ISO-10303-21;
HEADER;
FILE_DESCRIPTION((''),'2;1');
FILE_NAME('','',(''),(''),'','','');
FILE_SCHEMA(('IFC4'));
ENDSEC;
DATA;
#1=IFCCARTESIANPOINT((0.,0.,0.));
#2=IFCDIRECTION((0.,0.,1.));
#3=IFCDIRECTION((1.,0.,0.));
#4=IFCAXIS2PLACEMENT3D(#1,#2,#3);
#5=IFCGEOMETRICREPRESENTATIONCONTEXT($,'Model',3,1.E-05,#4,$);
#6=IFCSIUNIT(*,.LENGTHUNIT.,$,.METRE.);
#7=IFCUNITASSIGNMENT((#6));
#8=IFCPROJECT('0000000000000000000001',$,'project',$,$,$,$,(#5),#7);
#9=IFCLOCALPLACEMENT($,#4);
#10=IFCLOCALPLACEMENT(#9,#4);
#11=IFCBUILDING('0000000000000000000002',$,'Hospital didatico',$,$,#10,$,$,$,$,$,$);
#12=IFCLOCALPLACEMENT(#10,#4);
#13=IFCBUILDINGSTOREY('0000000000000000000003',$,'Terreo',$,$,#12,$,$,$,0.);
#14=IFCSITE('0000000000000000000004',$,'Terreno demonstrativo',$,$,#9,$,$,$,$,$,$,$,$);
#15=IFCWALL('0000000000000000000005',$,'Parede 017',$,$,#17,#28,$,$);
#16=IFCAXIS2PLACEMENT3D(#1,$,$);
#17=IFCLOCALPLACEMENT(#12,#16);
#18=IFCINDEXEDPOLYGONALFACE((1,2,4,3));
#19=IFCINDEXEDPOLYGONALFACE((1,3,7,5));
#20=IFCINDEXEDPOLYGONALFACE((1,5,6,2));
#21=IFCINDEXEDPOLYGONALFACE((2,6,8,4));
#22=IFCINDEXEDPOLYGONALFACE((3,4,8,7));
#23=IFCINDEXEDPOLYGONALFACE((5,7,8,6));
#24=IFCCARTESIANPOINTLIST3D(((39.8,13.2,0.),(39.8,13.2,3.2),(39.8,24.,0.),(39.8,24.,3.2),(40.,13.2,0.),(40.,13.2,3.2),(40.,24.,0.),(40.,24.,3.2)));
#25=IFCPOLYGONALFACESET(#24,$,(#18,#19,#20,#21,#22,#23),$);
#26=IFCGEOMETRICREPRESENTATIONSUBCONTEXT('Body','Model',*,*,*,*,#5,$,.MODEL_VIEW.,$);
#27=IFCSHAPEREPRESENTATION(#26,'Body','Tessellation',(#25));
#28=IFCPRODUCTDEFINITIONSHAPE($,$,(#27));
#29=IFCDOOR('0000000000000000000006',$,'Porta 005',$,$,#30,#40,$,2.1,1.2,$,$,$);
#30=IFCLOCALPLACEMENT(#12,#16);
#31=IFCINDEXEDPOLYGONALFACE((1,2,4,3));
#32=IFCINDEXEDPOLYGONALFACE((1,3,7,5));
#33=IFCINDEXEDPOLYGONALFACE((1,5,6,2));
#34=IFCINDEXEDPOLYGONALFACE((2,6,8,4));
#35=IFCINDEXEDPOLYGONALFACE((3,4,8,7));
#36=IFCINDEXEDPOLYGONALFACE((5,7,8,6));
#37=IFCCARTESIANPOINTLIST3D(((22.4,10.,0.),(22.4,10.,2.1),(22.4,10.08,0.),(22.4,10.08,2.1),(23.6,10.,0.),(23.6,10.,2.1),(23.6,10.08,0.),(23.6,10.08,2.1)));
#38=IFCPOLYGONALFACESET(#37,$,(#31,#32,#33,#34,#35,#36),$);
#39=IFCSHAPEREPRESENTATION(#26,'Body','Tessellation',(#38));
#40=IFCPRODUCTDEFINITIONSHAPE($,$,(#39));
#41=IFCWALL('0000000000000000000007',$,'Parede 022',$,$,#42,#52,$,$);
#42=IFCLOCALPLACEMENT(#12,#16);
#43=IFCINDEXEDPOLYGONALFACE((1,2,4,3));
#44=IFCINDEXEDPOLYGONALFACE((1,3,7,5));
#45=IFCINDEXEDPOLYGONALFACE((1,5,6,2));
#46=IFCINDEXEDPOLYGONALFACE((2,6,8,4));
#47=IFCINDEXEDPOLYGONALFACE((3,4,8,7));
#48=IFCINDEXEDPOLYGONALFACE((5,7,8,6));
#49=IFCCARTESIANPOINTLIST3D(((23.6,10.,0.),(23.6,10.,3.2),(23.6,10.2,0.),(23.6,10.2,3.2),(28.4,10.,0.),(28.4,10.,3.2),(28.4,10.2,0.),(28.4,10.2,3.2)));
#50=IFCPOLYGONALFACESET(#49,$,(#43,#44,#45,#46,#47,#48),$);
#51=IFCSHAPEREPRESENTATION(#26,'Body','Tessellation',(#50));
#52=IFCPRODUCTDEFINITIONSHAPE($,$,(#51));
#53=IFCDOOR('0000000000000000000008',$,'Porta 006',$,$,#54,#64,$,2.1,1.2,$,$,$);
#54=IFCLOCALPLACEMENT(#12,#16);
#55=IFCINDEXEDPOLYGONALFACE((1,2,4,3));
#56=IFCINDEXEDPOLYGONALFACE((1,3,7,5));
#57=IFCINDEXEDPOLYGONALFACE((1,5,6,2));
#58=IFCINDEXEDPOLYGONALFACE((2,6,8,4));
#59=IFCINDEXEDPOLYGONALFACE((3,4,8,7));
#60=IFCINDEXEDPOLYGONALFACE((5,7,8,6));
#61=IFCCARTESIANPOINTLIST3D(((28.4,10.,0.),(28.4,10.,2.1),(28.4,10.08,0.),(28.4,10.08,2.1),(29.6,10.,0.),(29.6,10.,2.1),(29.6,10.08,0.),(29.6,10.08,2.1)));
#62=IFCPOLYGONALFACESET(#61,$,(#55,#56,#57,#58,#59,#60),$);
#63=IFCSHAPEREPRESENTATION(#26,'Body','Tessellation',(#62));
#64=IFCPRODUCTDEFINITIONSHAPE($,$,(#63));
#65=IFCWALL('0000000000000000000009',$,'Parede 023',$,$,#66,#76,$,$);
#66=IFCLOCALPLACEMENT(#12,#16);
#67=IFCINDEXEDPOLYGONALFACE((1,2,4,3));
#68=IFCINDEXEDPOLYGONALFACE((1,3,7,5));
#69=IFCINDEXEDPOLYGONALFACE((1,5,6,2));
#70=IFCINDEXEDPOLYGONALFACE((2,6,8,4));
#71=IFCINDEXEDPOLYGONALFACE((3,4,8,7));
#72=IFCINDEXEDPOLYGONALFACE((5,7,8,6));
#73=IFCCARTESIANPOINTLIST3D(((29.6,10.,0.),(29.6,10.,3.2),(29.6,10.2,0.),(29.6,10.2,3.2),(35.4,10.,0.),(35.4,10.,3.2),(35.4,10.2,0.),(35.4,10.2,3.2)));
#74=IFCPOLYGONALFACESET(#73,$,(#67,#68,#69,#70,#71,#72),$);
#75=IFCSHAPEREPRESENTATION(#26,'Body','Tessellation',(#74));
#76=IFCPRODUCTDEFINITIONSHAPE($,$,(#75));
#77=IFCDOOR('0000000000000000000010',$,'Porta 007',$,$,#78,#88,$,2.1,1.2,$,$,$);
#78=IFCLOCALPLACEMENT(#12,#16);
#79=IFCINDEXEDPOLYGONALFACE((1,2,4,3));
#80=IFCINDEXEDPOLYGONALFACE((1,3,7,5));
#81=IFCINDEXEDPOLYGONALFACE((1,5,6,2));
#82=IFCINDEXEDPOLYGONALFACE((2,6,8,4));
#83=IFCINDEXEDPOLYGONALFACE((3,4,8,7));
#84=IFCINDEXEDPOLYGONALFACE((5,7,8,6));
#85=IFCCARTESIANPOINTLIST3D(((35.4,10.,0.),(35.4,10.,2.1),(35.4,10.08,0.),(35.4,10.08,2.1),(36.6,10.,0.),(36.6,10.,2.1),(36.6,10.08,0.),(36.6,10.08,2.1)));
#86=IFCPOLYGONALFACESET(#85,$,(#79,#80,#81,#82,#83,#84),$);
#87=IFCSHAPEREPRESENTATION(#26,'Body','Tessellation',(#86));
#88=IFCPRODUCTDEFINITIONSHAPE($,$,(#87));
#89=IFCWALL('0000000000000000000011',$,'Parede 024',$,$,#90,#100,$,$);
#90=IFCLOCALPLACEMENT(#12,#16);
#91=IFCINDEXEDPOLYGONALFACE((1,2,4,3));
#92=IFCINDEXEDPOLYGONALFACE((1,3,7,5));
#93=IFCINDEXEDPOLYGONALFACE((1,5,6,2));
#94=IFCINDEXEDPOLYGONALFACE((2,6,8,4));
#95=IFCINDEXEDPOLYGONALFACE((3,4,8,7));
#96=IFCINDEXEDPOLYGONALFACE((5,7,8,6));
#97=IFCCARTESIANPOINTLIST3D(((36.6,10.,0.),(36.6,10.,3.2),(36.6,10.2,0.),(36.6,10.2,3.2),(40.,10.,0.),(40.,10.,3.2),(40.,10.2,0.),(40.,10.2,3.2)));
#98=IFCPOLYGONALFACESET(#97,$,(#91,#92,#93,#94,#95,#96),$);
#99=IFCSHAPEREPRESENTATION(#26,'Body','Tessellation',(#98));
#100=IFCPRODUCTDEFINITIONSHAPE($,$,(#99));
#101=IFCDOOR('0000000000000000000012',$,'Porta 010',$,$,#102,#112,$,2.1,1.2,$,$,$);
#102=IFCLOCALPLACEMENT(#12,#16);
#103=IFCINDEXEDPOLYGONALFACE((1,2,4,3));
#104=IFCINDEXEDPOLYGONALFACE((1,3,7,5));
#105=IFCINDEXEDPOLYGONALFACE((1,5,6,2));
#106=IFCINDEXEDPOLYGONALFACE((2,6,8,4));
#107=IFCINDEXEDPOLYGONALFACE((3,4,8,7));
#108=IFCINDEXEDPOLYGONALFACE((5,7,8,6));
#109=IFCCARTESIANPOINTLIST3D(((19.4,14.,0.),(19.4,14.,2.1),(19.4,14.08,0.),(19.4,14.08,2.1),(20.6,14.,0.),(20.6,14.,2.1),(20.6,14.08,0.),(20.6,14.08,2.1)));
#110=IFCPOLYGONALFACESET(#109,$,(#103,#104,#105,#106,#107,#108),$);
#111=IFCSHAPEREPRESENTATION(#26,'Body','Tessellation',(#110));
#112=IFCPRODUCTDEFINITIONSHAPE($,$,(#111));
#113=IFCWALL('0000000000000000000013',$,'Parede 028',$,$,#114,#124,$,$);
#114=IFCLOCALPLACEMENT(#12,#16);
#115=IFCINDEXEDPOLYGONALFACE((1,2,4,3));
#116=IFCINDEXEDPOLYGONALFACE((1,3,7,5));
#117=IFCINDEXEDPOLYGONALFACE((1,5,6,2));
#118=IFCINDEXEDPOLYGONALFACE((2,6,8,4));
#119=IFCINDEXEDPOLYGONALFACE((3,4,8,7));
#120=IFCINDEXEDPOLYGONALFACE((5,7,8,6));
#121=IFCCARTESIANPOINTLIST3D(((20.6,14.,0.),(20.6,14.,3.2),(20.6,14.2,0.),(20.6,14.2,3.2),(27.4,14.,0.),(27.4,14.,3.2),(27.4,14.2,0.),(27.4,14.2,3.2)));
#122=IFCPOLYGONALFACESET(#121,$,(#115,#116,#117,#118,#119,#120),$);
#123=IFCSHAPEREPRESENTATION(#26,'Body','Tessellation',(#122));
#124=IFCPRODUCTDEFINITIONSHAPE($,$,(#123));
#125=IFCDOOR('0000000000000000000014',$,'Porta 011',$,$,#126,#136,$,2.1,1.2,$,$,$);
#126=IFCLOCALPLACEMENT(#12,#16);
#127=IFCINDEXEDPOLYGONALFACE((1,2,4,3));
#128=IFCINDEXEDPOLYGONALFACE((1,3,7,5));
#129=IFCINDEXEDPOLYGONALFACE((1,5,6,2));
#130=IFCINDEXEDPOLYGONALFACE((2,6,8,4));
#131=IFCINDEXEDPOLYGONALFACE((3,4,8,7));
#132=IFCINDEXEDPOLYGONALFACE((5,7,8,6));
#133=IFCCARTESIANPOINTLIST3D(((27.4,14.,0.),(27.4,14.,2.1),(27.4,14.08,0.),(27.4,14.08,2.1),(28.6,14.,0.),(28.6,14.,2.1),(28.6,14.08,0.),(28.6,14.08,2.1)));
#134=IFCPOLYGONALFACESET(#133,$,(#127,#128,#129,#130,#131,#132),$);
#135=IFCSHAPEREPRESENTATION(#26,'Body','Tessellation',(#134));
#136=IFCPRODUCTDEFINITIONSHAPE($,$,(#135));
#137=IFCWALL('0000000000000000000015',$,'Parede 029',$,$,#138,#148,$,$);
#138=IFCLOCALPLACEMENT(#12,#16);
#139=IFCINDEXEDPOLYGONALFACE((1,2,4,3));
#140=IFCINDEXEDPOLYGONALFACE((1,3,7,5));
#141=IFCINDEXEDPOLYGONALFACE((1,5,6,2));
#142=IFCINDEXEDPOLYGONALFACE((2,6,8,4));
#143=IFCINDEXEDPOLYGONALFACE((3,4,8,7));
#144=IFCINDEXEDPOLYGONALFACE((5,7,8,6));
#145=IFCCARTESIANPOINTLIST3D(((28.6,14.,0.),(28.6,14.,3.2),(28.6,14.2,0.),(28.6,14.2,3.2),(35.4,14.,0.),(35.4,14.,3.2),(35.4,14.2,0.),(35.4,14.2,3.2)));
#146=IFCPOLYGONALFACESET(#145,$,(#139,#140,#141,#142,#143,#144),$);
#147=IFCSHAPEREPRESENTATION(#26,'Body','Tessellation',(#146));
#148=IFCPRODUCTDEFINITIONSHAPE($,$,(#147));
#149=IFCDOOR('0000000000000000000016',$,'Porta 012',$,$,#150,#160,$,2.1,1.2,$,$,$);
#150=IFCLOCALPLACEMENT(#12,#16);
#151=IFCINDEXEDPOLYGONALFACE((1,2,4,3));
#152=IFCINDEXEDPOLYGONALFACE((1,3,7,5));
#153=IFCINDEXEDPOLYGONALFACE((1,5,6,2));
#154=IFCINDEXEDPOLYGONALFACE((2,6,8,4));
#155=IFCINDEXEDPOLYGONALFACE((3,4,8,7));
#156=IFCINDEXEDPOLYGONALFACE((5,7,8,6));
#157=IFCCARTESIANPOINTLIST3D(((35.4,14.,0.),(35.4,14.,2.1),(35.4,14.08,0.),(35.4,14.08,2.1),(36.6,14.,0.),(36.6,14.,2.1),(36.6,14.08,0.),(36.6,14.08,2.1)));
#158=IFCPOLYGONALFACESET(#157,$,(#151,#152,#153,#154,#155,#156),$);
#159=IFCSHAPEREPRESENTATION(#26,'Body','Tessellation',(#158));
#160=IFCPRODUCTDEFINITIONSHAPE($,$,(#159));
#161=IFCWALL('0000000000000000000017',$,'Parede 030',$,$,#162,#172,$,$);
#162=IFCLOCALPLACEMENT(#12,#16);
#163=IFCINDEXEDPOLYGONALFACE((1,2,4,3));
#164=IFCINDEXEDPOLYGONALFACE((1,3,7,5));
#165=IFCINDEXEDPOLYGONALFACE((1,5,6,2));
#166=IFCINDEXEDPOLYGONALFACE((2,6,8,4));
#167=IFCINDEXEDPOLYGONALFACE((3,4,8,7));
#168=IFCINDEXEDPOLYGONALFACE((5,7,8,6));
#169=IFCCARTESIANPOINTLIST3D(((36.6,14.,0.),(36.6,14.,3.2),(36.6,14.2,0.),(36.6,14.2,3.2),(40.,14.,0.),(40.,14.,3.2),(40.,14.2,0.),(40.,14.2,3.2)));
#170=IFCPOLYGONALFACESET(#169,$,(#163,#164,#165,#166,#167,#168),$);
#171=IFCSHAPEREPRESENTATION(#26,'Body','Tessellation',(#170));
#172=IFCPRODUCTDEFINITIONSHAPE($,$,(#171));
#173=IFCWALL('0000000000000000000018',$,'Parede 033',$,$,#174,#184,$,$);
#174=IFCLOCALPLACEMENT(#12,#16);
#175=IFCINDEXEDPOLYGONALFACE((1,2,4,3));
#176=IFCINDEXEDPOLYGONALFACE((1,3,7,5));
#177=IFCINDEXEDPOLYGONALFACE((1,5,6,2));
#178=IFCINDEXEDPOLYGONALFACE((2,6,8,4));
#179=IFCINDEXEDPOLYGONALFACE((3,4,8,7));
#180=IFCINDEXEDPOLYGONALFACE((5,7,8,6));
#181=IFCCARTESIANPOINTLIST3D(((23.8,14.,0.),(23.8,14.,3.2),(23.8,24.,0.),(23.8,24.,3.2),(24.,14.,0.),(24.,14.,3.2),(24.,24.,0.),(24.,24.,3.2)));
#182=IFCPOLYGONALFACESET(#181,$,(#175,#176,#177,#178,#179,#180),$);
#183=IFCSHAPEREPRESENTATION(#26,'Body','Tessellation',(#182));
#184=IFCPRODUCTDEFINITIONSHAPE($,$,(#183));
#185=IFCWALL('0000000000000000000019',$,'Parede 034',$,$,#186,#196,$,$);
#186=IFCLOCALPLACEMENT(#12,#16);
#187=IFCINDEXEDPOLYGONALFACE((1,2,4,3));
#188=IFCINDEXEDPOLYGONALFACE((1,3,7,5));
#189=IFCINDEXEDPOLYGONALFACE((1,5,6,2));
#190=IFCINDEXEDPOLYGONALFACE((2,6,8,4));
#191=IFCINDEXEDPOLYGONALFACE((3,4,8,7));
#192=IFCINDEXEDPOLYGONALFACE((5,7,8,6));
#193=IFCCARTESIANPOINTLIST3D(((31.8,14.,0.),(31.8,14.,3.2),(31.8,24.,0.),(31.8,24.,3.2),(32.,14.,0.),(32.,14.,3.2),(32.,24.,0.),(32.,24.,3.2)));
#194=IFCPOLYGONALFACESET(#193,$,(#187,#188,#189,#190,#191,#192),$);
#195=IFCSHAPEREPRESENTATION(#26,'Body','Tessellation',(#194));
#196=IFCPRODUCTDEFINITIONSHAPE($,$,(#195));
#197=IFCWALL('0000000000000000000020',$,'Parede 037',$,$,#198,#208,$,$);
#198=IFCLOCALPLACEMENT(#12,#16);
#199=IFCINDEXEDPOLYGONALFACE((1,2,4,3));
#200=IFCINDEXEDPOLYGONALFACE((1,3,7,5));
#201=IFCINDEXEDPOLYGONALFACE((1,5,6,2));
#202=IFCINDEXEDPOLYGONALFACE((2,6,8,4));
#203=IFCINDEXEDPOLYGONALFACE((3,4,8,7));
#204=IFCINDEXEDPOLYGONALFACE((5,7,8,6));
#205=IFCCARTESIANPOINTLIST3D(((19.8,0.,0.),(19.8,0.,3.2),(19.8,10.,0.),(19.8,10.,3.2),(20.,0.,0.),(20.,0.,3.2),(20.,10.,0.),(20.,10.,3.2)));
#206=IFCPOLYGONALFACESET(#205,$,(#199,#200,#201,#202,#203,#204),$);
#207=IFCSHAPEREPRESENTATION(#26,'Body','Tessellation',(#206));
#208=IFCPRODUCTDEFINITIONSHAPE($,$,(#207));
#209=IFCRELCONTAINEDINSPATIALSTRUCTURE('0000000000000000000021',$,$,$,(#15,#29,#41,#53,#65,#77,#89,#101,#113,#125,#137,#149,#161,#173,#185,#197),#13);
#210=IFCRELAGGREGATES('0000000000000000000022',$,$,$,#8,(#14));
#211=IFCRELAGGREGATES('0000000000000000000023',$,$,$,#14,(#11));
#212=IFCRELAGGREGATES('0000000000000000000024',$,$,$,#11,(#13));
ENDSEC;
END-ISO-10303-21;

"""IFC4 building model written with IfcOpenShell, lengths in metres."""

from ifc_helpers import new_model, si_unit, frame, origin_with_axes, place, context, subcontext, project, spatial, indexed_curve, outline, extrude, element, save


model = new_model("IFC4")

# Units and contexts
model_context = context("Model", 3, precision=1e-05, world=origin_with_axes())
body_context = subcontext(model_context, "Body", "Model", "MODEL_VIEW")
ifc_project = project(units=[si_unit("LENGTHUNIT", "METRE")], contexts=[model_context])

# Site, building, storey
site_placement = place(None, origin_with_axes())
site = spatial("IfcSite", under=ifc_project, at=site_placement, Name="Terreno demonstrativo")
building_placement = place(site_placement, origin_with_axes())
building = spatial("IfcBuilding", under=site, at=building_placement, Name="Hospital didatico")
storey_placement = place(building_placement, origin_with_axes())
storey = spatial("IfcBuildingStorey", under=building, at=storey_placement, Name="Terreo", Elevation=0.0)

# Wall
wall_1_placement = place(storey_placement, frame((40.0, 13.2, 0.0), z_axis=(0.0, 0.0, 1.0), x_axis=(0.0, 1.0, 0.0)))
element("IfcWall", 1, at=wall_1_placement, inside=storey, Name="Parede 017", context=body_context, shape_type="SweptSolid", body=[
    extrude(outline(indexed_curve([(0.0, 0.0), (0.0, 0.2), (10.8, 0.2), (10.8, 0.0), (0.0, 0.0)], self_intersect=False)), origin_with_axes(), (0.0, 0.0, 1.0), 3.2),
])

# Door
door_1_placement = place(storey_placement, frame((22.4, 10.0, 0.0), z_axis=(0.0, 0.0, 1.0), x_axis=(1.0, 0.0, 0.0)))
element("IfcDoor", 2, at=door_1_placement, inside=storey, Name="Porta 005", OverallHeight=2.1, OverallWidth=1.2, context=body_context, shape_type="SweptSolid", body=[
    extrude(outline(indexed_curve([(0.0, 0.0), (0.0, 0.08), (1.2, 0.08), (1.2, 0.0), (0.0, 0.0)], self_intersect=False)), origin_with_axes(), (0.0, 0.0, 1.0), 2.1),
])

# Wall
wall_2_placement = place(storey_placement, frame((23.6, 10.0, 0.0), z_axis=(0.0, 0.0, 1.0), x_axis=(1.0, 0.0, 0.0)))
element("IfcWall", 3, at=wall_2_placement, inside=storey, Name="Parede 022", context=body_context, shape_type="SweptSolid", body=[
    extrude(outline(indexed_curve([(0.0, 0.0), (0.0, 0.2), (4.8, 0.2), (4.8, 0.0), (0.0, 0.0)], self_intersect=False)), origin_with_axes(), (0.0, 0.0, 1.0), 3.2),
])

# Door
door_2_placement = place(storey_placement, frame((28.4, 10.0, 0.0), z_axis=(0.0, 0.0, 1.0), x_axis=(1.0, 0.0, 0.0)))
element("IfcDoor", 4, at=door_2_placement, inside=storey, Name="Porta 006", OverallHeight=2.1, OverallWidth=1.2, context=body_context, shape_type="SweptSolid", body=[
    extrude(outline(indexed_curve([(0.0, 0.0), (0.0, 0.08), (1.2, 0.08), (1.2, 0.0), (0.0, 0.0)], self_intersect=False)), origin_with_axes(), (0.0, 0.0, 1.0), 2.1),
])

# Wall
wall_3_placement = place(storey_placement, frame((29.6, 10.0, 0.0), z_axis=(0.0, 0.0, 1.0), x_axis=(1.0, 0.0, 0.0)))
element("IfcWall", 5, at=wall_3_placement, inside=storey, Name="Parede 023", context=body_context, shape_type="SweptSolid", body=[
    extrude(outline(indexed_curve([(0.0, 0.0), (0.0, 0.2), (5.8, 0.2), (5.8, 0.0), (0.0, 0.0)], self_intersect=False)), origin_with_axes(), (0.0, 0.0, 1.0), 3.2),
])

# Door
door_3_placement = place(storey_placement, frame((35.4, 10.0, 0.0), z_axis=(0.0, 0.0, 1.0), x_axis=(1.0, 0.0, 0.0)))
element("IfcDoor", 6, at=door_3_placement, inside=storey, Name="Porta 007", OverallHeight=2.1, OverallWidth=1.2, context=body_context, shape_type="SweptSolid", body=[
    extrude(outline(indexed_curve([(0.0, 0.0), (0.0, 0.08), (1.2, 0.08), (1.2, 0.0), (0.0, 0.0)], self_intersect=False)), origin_with_axes(), (0.0, 0.0, 1.0), 2.1),
])

# Wall
wall_4_placement = place(storey_placement, frame((36.6, 10.0, 0.0), z_axis=(0.0, 0.0, 1.0), x_axis=(1.0, 0.0, 0.0)))
element("IfcWall", 7, at=wall_4_placement, inside=storey, Name="Parede 024", context=body_context, shape_type="SweptSolid", body=[
    extrude(outline(indexed_curve([(0.0, 0.0), (0.0, 0.2), (3.4, 0.2), (3.4, 0.0), (0.0, 0.0)], self_intersect=False)), origin_with_axes(), (0.0, 0.0, 1.0), 3.2),
])

# Door
door_4_placement = place(storey_placement, frame((19.4, 14.0, 0.0), z_axis=(0.0, 0.0, 1.0), x_axis=(1.0, 0.0, 0.0)))
element("IfcDoor", 8, at=door_4_placement, inside=storey, Name="Porta 010", OverallHeight=2.1, OverallWidth=1.2, context=body_context, shape_type="SweptSolid", body=[
    extrude(outline(indexed_curve([(0.0, 0.0), (0.0, 0.08), (1.2, 0.08), (1.2, 0.0), (0.0, 0.0)], self_intersect=False)), origin_with_axes(), (0.0, 0.0, 1.0), 2.1),
])

# Wall
wall_5_placement = place(storey_placement, frame((20.6, 14.0, 0.0), z_axis=(0.0, 0.0, 1.0), x_axis=(1.0, 0.0, 0.0)))
element("IfcWall", 9, at=wall_5_placement, inside=storey, Name="Parede 028", context=body_context, shape_type="SweptSolid", body=[
    extrude(outline(indexed_curve([(0.0, 0.0), (0.0, 0.2), (6.8, 0.2), (6.8, 0.0), (0.0, 0.0)], self_intersect=False)), origin_with_axes(), (0.0, 0.0, 1.0), 3.2),
])

# Door
door_5_placement = place(storey_placement, frame((27.4, 14.0, 0.0), z_axis=(0.0, 0.0, 1.0), x_axis=(1.0, 0.0, 0.0)))
element("IfcDoor", 10, at=door_5_placement, inside=storey, Name="Porta 011", OverallHeight=2.1, OverallWidth=1.2, context=body_context, shape_type="SweptSolid", body=[
    extrude(outline(indexed_curve([(0.0, 0.0), (0.0, 0.08), (1.2, 0.08), (1.2, 0.0), (0.0, 0.0)], self_intersect=False)), origin_with_axes(), (0.0, 0.0, 1.0), 2.1),
])

# Wall
wall_6_placement = place(storey_placement, frame((28.6, 14.0, 0.0), z_axis=(0.0, 0.0, 1.0), x_axis=(1.0, 0.0, 0.0)))
element("IfcWall", 11, at=wall_6_placement, inside=storey, Name="Parede 029", context=body_context, shape_type="SweptSolid", body=[
    extrude(outline(indexed_curve([(0.0, 0.0), (0.0, 0.2), (6.8, 0.2), (6.8, 0.0), (0.0, 0.0)], self_intersect=False)), origin_with_axes(), (0.0, 0.0, 1.0), 3.2),
])

# Door
door_6_placement = place(storey_placement, frame((35.4, 14.0, 0.0), z_axis=(0.0, 0.0, 1.0), x_axis=(1.0, 0.0, 0.0)))
element("IfcDoor", 12, at=door_6_placement, inside=storey, Name="Porta 012", OverallHeight=2.1, OverallWidth=1.2, context=body_context, shape_type="SweptSolid", body=[
    extrude(outline(indexed_curve([(0.0, 0.0), (0.0, 0.08), (1.2, 0.08), (1.2, 0.0), (0.0, 0.0)], self_intersect=False)), origin_with_axes(), (0.0, 0.0, 1.0), 2.1),
])

# Walls
wall_7_placement = place(storey_placement, frame((36.6, 14.0, 0.0), z_axis=(0.0, 0.0, 1.0), x_axis=(1.0, 0.0, 0.0)))
element("IfcWall", 13, at=wall_7_placement, inside=storey, Name="Parede 030", context=body_context, shape_type="SweptSolid", body=[
    extrude(outline(indexed_curve([(0.0, 0.0), (0.0, 0.2), (3.4, 0.2), (3.4, 0.0), (0.0, 0.0)], self_intersect=False)), origin_with_axes(), (0.0, 0.0, 1.0), 3.2),
])
for number, where, z_axis, x_axis, name in (
    (14, (24.0, 14.0, 0.0), (0.0, 0.0, 1.0), (0.0, 1.0, 0.0), "Parede 033"),
    (15, (32.0, 14.0, 0.0), (0.0, 0.0, 1.0), (0.0, 1.0, 0.0), "Parede 034"),
    (16, (20.0, 0.0, 0.0), (0.0, 0.0, 1.0), (0.0, 1.0, 0.0), "Parede 037"),
):
    element("IfcWall", number, at=place(storey_placement, frame(where, z_axis=z_axis, x_axis=x_axis)), inside=storey, Name=name, context=body_context, shape_type="SweptSolid", body=[
        extrude(outline(indexed_curve([(0.0, 0.0), (0.0, 0.2), (10.0, 0.2), (10.0, 0.0), (0.0, 0.0)], self_intersect=False)), origin_with_axes(), (0.0, 0.0, 1.0), 3.2),
    ])

save(model, "model.ifc")
